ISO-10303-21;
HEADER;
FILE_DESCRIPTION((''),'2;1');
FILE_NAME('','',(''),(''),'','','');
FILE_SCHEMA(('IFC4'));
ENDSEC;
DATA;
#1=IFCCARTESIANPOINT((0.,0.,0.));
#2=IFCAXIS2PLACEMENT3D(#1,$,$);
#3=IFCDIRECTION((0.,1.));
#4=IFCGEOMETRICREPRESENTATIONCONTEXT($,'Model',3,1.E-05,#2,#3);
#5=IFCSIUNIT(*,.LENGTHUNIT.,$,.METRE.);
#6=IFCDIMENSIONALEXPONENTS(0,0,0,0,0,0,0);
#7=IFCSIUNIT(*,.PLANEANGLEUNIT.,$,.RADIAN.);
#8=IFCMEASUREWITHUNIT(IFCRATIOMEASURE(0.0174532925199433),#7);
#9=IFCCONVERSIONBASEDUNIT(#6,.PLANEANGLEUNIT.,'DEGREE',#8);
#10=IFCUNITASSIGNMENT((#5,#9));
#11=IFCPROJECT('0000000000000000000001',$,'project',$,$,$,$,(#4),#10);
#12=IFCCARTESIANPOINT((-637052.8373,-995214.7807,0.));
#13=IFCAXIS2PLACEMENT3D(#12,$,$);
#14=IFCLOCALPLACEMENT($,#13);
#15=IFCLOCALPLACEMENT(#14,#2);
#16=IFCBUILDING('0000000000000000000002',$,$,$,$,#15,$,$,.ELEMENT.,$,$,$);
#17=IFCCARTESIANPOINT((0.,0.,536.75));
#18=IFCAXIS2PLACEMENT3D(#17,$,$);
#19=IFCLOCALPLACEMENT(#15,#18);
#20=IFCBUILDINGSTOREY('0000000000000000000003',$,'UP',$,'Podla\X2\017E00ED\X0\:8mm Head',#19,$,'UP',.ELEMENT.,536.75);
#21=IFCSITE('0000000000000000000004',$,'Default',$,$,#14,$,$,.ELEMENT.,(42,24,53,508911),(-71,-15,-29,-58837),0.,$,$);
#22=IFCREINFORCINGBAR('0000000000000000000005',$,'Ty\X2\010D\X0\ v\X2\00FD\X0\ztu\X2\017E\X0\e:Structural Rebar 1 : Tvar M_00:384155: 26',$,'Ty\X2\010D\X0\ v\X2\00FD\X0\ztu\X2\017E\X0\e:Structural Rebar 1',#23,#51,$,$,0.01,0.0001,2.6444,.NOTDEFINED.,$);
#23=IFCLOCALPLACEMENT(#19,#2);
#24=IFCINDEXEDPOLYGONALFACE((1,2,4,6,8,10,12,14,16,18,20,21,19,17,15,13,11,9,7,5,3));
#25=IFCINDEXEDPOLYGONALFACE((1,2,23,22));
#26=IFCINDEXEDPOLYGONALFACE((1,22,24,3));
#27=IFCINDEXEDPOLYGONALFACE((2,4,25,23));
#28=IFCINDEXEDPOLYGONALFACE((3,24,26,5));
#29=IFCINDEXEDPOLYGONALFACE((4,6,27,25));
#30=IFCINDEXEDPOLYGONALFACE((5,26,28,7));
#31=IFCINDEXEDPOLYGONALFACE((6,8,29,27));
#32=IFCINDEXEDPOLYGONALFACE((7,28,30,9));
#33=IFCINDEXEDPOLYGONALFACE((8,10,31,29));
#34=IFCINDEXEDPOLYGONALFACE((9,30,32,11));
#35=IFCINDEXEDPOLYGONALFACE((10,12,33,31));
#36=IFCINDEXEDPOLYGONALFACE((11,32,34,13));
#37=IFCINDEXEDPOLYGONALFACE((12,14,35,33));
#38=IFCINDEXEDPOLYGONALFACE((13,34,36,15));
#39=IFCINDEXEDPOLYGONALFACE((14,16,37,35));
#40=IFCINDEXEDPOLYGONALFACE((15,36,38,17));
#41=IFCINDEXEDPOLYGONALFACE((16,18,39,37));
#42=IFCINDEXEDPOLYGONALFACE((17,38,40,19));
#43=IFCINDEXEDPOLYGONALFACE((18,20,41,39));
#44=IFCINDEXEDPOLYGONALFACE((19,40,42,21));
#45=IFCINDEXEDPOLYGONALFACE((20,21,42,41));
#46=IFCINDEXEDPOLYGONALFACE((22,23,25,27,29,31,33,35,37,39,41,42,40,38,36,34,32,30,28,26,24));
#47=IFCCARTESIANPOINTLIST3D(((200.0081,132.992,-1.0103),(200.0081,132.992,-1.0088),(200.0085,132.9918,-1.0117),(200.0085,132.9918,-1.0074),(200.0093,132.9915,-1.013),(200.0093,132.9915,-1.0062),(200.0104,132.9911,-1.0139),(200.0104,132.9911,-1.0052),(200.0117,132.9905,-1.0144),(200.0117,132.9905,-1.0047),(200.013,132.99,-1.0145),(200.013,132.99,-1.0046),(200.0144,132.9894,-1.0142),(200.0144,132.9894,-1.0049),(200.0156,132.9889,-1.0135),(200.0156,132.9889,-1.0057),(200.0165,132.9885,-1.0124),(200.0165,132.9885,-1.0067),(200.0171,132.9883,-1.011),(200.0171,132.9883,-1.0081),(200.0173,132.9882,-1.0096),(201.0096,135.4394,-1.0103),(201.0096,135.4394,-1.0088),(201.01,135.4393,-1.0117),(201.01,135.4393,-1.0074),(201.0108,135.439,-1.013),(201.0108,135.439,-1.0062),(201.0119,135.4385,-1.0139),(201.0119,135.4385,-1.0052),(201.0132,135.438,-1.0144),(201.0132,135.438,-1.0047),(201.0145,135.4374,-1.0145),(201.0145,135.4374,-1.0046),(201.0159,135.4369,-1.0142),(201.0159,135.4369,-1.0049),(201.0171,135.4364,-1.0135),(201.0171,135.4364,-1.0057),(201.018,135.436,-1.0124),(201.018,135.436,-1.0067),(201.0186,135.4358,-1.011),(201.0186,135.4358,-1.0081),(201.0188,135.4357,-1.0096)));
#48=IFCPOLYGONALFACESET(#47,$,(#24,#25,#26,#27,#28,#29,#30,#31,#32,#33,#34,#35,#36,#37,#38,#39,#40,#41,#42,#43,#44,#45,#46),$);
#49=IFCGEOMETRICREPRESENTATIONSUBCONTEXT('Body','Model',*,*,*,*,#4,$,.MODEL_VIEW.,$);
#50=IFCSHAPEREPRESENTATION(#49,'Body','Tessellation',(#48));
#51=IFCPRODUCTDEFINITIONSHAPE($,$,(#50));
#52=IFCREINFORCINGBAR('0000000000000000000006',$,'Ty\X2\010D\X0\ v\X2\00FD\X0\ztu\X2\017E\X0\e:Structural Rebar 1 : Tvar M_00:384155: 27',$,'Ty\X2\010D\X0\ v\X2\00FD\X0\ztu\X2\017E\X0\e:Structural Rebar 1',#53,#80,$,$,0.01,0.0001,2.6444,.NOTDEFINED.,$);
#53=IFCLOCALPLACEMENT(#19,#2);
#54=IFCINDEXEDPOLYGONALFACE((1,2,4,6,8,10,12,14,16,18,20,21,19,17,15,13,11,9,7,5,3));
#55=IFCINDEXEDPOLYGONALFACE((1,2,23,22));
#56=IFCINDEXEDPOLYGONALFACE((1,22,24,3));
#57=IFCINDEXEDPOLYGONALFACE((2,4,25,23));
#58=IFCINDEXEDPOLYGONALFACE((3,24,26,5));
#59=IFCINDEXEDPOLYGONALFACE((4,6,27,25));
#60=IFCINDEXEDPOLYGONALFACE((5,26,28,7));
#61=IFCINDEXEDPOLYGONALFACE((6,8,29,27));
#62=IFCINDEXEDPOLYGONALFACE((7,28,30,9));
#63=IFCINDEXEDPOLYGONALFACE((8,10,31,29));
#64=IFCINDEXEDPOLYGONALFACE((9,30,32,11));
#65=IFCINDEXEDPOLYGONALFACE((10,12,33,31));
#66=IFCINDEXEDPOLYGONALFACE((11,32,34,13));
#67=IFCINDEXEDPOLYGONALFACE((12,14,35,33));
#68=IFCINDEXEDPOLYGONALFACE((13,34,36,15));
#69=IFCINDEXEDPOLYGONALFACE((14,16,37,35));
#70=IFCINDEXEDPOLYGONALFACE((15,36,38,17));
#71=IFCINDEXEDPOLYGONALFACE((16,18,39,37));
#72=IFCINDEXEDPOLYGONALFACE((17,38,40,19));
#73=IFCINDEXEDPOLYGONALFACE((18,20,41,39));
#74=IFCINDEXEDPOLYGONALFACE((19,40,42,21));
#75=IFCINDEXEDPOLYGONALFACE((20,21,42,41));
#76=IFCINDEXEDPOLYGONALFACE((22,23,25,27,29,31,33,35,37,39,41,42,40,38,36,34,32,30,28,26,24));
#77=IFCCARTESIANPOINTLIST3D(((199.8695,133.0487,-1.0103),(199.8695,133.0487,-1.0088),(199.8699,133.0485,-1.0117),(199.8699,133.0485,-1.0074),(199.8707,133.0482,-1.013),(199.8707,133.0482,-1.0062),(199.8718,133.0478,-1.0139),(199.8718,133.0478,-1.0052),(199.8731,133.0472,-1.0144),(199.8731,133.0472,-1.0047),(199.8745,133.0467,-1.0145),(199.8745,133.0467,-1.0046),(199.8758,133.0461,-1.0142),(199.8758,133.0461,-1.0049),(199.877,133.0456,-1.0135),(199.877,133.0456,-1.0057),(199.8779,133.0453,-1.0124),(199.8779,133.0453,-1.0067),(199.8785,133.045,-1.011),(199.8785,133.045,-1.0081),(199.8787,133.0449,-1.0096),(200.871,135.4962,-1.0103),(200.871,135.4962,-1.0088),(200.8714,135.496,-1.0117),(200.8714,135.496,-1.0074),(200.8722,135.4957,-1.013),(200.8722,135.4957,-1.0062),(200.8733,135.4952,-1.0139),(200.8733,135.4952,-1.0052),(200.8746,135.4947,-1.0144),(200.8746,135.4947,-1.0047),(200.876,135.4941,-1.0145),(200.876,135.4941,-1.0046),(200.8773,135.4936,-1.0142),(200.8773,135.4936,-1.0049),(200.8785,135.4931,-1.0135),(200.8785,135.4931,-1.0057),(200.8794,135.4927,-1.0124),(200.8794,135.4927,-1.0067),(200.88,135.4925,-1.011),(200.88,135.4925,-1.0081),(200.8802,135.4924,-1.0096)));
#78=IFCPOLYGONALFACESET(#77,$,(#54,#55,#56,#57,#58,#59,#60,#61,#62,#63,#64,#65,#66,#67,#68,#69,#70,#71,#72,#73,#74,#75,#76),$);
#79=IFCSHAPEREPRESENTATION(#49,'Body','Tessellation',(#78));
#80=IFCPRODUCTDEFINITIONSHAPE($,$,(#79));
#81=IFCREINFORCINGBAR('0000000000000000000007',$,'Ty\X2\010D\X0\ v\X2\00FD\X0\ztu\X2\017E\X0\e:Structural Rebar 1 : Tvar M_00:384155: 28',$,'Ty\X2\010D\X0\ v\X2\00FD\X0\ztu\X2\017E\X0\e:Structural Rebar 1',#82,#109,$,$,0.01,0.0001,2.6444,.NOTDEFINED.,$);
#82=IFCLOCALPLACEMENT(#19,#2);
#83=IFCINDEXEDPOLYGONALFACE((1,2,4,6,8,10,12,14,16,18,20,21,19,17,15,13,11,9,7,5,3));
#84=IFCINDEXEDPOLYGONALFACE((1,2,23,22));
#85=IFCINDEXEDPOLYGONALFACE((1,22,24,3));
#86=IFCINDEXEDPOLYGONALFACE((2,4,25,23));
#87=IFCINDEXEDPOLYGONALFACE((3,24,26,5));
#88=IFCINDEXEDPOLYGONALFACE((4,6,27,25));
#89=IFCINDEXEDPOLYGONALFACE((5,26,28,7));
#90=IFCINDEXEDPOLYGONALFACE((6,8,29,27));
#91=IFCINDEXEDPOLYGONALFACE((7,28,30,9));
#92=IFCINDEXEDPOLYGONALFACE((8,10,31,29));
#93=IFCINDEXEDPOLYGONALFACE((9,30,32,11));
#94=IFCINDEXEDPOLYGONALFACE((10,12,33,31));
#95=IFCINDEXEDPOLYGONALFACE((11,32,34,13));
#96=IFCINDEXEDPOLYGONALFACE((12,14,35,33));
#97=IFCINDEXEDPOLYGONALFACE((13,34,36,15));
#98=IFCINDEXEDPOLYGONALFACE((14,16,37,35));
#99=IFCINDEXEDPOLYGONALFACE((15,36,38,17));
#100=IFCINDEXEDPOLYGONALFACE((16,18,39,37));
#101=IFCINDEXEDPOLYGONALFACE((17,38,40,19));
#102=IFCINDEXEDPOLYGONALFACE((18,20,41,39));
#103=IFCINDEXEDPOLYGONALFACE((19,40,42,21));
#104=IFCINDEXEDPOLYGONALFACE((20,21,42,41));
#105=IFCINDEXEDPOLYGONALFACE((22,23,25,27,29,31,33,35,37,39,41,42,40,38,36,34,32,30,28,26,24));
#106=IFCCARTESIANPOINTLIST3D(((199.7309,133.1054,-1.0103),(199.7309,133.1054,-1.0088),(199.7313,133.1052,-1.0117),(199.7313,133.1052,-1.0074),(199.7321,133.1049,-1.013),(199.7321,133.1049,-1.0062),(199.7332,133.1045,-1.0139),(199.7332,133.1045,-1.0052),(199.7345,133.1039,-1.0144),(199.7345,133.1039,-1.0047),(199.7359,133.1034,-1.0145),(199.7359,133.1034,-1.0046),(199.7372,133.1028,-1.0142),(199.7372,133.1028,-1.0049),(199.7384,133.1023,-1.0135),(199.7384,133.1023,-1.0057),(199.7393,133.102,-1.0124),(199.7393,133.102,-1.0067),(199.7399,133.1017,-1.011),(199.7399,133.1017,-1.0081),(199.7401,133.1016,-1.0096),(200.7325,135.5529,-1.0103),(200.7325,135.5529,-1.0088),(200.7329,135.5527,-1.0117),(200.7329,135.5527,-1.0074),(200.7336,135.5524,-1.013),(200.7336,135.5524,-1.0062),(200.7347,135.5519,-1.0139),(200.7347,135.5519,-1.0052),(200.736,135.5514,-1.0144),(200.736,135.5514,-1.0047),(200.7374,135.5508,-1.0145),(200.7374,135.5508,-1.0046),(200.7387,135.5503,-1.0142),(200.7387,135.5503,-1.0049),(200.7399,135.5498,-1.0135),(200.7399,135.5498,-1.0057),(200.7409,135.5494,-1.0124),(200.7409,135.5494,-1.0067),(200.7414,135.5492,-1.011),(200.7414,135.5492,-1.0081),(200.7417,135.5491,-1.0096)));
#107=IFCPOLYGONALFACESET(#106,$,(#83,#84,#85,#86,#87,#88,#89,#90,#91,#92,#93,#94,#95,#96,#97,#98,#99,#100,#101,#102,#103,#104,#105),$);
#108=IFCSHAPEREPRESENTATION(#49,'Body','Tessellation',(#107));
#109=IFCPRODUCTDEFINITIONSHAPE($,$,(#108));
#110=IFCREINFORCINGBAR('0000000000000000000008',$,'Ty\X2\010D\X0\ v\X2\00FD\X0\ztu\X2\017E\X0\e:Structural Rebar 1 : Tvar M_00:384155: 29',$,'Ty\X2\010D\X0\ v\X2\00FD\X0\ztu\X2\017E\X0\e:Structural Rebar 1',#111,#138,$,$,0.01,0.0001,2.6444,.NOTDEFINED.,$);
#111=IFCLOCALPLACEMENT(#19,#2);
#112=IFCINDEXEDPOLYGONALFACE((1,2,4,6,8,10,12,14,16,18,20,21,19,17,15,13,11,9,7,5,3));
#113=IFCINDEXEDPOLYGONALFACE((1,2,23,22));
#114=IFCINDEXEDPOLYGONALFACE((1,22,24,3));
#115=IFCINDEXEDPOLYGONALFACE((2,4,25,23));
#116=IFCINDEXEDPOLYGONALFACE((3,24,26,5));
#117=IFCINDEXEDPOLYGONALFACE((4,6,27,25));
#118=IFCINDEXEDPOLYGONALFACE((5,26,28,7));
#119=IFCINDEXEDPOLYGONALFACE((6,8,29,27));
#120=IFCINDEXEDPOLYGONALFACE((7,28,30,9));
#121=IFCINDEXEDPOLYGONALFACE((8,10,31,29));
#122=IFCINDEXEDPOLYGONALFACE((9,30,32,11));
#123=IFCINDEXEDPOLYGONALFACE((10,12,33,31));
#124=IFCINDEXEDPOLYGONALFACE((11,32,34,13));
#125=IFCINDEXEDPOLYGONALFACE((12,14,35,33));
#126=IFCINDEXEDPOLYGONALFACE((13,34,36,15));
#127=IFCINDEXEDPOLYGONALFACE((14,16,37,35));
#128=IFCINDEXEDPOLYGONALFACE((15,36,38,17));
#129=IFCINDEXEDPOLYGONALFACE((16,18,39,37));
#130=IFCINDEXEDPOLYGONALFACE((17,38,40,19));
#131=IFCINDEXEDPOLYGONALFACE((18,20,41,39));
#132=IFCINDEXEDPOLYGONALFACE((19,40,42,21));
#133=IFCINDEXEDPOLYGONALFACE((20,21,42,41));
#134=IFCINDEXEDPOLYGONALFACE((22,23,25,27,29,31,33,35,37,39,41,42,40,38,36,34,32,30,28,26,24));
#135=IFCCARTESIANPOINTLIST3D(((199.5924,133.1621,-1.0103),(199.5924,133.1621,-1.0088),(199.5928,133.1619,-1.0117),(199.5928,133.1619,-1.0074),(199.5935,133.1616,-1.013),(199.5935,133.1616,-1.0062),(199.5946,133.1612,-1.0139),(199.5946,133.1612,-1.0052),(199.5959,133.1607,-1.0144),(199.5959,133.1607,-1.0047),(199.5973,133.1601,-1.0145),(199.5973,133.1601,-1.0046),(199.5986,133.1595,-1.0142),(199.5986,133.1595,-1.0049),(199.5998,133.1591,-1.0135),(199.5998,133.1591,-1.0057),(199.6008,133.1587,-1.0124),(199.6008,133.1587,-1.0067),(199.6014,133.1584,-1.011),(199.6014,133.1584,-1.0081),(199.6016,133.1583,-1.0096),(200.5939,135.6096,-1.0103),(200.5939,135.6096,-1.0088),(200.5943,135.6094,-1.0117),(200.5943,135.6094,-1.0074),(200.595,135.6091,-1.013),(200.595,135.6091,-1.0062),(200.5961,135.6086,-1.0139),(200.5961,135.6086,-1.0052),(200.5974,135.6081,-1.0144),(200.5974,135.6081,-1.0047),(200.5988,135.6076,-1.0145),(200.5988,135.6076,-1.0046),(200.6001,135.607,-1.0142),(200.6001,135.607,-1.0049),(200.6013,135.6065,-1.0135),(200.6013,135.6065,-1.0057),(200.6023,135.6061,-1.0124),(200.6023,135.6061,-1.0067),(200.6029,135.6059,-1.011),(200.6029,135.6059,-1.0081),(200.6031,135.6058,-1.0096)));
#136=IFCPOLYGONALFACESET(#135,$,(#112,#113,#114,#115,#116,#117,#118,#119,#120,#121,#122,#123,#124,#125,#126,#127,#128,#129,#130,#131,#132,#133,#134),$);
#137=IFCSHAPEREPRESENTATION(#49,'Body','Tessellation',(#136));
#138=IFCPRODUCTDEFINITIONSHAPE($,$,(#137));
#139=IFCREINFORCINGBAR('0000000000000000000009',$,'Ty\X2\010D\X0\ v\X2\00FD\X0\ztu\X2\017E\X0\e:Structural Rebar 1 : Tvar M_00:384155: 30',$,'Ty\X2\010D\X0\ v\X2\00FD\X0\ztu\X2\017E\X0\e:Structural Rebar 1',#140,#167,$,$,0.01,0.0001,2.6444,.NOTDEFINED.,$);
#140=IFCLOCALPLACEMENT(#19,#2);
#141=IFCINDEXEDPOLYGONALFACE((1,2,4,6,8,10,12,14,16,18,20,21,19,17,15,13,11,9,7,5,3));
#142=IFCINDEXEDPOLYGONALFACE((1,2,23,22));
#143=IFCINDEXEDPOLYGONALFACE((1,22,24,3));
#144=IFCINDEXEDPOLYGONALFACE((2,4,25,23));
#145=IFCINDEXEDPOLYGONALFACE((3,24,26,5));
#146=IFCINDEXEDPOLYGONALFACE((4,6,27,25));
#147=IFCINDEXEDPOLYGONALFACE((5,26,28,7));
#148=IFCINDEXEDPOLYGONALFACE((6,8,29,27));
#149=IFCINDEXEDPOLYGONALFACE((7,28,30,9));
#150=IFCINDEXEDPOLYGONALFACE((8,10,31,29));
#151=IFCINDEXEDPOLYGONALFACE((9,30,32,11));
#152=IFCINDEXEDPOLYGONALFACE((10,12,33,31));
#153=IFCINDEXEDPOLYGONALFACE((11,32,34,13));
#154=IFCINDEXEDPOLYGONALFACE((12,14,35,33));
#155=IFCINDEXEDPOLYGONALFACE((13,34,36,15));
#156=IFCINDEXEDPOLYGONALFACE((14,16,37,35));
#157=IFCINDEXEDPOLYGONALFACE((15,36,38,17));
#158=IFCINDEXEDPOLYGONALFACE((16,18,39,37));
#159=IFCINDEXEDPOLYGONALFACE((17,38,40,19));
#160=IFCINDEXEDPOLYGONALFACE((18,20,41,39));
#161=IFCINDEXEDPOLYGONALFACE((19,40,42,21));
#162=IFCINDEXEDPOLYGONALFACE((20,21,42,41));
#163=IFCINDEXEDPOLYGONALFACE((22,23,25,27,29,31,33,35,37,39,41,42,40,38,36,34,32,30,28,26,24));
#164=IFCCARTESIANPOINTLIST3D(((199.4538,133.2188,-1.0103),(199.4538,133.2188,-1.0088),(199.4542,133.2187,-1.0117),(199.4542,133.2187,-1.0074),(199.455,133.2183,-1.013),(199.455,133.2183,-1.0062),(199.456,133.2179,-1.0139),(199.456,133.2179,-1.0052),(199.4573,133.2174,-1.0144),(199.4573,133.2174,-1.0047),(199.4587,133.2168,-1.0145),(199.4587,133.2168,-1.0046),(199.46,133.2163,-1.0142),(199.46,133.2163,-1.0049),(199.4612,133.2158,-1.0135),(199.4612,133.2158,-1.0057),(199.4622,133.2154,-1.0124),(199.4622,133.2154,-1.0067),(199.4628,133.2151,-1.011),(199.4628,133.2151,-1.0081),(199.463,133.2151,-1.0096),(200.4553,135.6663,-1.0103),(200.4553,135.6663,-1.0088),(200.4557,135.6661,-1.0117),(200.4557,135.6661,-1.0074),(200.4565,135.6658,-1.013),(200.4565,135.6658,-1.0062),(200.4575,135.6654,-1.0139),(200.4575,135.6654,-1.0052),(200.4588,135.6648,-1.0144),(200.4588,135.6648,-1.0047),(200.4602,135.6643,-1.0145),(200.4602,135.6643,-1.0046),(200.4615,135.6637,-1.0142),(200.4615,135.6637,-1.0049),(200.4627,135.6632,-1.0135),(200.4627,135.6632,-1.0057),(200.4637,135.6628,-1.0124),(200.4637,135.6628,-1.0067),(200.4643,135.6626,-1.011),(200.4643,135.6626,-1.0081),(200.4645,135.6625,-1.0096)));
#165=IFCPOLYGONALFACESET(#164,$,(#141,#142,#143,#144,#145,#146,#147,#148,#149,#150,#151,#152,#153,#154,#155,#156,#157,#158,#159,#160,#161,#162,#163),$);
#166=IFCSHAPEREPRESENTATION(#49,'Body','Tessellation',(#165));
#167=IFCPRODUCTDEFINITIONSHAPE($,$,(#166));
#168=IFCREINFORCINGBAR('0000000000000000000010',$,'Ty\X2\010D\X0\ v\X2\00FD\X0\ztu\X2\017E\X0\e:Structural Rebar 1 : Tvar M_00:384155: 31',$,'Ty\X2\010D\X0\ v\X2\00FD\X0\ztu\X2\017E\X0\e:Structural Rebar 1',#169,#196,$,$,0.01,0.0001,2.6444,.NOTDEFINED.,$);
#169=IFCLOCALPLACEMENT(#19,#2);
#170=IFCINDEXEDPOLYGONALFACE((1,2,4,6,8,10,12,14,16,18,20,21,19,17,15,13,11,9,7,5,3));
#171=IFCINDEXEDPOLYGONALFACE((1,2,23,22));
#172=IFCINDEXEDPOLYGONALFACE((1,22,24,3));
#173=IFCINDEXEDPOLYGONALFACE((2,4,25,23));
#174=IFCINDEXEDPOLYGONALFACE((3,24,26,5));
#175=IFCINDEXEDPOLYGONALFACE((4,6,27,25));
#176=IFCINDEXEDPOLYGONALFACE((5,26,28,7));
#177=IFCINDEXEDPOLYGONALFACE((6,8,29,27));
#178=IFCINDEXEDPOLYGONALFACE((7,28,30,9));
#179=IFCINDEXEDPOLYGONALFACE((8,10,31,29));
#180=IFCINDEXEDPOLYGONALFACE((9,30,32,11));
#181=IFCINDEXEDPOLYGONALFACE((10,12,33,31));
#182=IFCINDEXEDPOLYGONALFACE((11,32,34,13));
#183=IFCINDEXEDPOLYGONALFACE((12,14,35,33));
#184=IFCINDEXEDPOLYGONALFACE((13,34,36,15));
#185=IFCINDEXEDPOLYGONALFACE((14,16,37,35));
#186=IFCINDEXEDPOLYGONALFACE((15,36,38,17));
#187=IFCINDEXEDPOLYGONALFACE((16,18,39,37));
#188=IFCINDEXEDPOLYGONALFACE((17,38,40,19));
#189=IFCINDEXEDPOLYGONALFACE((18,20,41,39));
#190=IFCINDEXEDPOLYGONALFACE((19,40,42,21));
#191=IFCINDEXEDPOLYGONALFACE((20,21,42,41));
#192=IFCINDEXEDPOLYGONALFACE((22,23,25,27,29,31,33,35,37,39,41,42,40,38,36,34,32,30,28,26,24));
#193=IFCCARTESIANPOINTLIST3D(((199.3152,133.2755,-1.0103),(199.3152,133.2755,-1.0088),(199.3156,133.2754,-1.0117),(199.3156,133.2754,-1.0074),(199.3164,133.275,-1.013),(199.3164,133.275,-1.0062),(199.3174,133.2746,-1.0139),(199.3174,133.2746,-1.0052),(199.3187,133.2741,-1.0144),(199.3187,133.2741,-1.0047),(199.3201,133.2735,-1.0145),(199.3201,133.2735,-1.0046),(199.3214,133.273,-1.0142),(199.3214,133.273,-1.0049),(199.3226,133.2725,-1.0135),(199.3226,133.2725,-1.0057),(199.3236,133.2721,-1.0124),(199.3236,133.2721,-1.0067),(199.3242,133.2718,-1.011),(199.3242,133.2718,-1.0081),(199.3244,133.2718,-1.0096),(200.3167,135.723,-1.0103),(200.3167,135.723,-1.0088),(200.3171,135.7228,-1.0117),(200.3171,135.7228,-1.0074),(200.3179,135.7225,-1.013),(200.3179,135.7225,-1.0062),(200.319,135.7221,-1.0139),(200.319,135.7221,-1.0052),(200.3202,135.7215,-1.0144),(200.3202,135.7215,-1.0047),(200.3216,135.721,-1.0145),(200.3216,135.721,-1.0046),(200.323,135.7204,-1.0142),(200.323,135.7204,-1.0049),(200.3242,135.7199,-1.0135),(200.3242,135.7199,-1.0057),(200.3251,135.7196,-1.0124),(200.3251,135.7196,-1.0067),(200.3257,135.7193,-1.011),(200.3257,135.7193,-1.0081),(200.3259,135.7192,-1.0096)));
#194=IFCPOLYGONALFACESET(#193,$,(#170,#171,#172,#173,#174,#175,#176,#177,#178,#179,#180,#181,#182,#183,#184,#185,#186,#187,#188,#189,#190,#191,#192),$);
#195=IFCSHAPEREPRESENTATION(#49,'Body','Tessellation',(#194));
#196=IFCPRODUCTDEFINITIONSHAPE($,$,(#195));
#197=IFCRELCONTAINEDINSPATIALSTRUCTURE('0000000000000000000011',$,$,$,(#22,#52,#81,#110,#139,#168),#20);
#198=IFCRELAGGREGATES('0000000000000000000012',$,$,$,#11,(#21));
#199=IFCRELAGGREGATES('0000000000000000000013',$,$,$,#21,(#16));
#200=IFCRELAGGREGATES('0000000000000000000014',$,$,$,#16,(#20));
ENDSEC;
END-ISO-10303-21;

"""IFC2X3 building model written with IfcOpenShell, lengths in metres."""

from ifc_helpers import new_model, entity, si_unit, converted_unit, direction, frame, origin, place, context, subcontext, project, spatial, element, save


model = new_model("IFC2X3")

# Units and contexts
model_context = context("Model", 3, precision=1e-05, world=origin(), true_north=direction((0.0, 1.0)))
body_context = subcontext(model_context, "Body", "Model", "MODEL_VIEW")
ifc_project = project(units=[si_unit("LENGTHUNIT", "METRE"), converted_unit("PLANEANGLEUNIT", "DEGREE", entity("IfcRatioMeasure", 0.0174532925199433), si_unit("PLANEANGLEUNIT", "RADIAN"), dimensions=[0, 0, 0, 0, 0, 0, 0])], contexts=[model_context])

# Site, building, storey
site_placement = place(None, frame((-637052.8373, -995214.7807, 0.0)))
site = spatial("IfcSite", under=ifc_project, at=site_placement, Name="Default", CompositionType="ELEMENT", RefLatitude=(42, 24, 53, 508911), RefLongitude=(-71, -15, -29, -58837), RefElevation=0.0)
building_placement = place(site_placement, origin())
building = spatial("IfcBuilding", under=site, at=building_placement, CompositionType="ELEMENT")
storey_placement = place(building_placement, frame((0.0, 0.0, 536.75)))
storey = spatial("IfcBuildingStorey", under=building, at=storey_placement, Name="UP", ObjectType="Podlaží:8mm Head", LongName="UP", CompositionType="ELEMENT", Elevation=536.75)

# Reinforcing bars
reinforcing_bar_1_placement = place(storey_placement, origin())
element("IfcReinforcingBar", 1, at=reinforcing_bar_1_placement, inside=storey, Name="Tyč výztuže:Structural Rebar 1 : Tvar M_00:384155: 26", ObjectType="Tyč výztuže:Structural Rebar 1", BarLength=2.6444, BarRole="NOTDEFINED", CrossSectionArea=0.0001, NominalDiameter=0.01, context=body_context, shape_type="AdvancedSweptSolid", body=[
    entity("IfcSweptDiskSolid", entity("IfcCompositeCurve", [entity("IfcCompositeCurveSegment", "CONTINUOUS", True, entity("IfcPolyline", [entity("IfcCartesianPoint", [-201.0142, -135.4376, 1.0096]), entity("IfcCartesianPoint", [-200.0127, -132.9901, 1.0096])]))], False), 0.005, None, 0.0, 1.0),
])
reinforcing_bar_2_placement = place(storey_placement, origin())
element("IfcReinforcingBar", 2, at=reinforcing_bar_2_placement, inside=storey, Name="Tyč výztuže:Structural Rebar 1 : Tvar M_00:384155: 27", ObjectType="Tyč výztuže:Structural Rebar 1", BarLength=2.6444, BarRole="NOTDEFINED", CrossSectionArea=0.0001, NominalDiameter=0.01, context=body_context, shape_type="AdvancedSweptSolid", body=[
    entity("IfcSweptDiskSolid", entity("IfcCompositeCurve", [entity("IfcCompositeCurveSegment", "CONTINUOUS", True, entity("IfcPolyline", [entity("IfcCartesianPoint", [-200.8756, -135.4943, 1.0096]), entity("IfcCartesianPoint", [-199.8741, -133.0468, 1.0096])]))], False), 0.005, None, 0.0, 1.0),
])
reinforcing_bar_3_placement = place(storey_placement, origin())
element("IfcReinforcingBar", 3, at=reinforcing_bar_3_placement, inside=storey, Name="Tyč výztuže:Structural Rebar 1 : Tvar M_00:384155: 28", ObjectType="Tyč výztuže:Structural Rebar 1", BarLength=2.6444, BarRole="NOTDEFINED", CrossSectionArea=0.0001, NominalDiameter=0.01, context=body_context, shape_type="AdvancedSweptSolid", body=[
    entity("IfcSweptDiskSolid", entity("IfcCompositeCurve", [entity("IfcCompositeCurveSegment", "CONTINUOUS", True, entity("IfcPolyline", [entity("IfcCartesianPoint", [-200.737, -135.551, 1.0096]), entity("IfcCartesianPoint", [-199.7355, -133.1035, 1.0096])]))], False), 0.005, None, 0.0, 1.0),
])
reinforcing_bar_4_placement = place(storey_placement, origin())
element("IfcReinforcingBar", 4, at=reinforcing_bar_4_placement, inside=storey, Name="Tyč výztuže:Structural Rebar 1 : Tvar M_00:384155: 29", ObjectType="Tyč výztuže:Structural Rebar 1", BarLength=2.6444, BarRole="NOTDEFINED", CrossSectionArea=0.0001, NominalDiameter=0.01, context=body_context, shape_type="AdvancedSweptSolid", body=[
    entity("IfcSweptDiskSolid", entity("IfcCompositeCurve", [entity("IfcCompositeCurveSegment", "CONTINUOUS", True, entity("IfcPolyline", [entity("IfcCartesianPoint", [-200.5984, -135.6077, 1.0096]), entity("IfcCartesianPoint", [-199.5969, -133.1602, 1.0096])]))], False), 0.005, None, 0.0, 1.0),
])
reinforcing_bar_5_placement = place(storey_placement, origin())
element("IfcReinforcingBar", 5, at=reinforcing_bar_5_placement, inside=storey, Name="Tyč výztuže:Structural Rebar 1 : Tvar M_00:384155: 30", ObjectType="Tyč výztuže:Structural Rebar 1", BarLength=2.6444, BarRole="NOTDEFINED", CrossSectionArea=0.0001, NominalDiameter=0.01, context=body_context, shape_type="AdvancedSweptSolid", body=[
    entity("IfcSweptDiskSolid", entity("IfcCompositeCurve", [entity("IfcCompositeCurveSegment", "CONTINUOUS", True, entity("IfcPolyline", [entity("IfcCartesianPoint", [-200.4599, -135.6644, 1.0096]), entity("IfcCartesianPoint", [-199.4583, -133.2169, 1.0096])]))], False), 0.005, None, 0.0, 1.0),
])
reinforcing_bar_6_placement = place(storey_placement, origin())
element("IfcReinforcingBar", 6, at=reinforcing_bar_6_placement, inside=storey, Name="Tyč výztuže:Structural Rebar 1 : Tvar M_00:384155: 31", ObjectType="Tyč výztuže:Structural Rebar 1", BarLength=2.6444, BarRole="NOTDEFINED", CrossSectionArea=0.0001, NominalDiameter=0.01, context=body_context, shape_type="AdvancedSweptSolid", body=[
    entity("IfcSweptDiskSolid", entity("IfcCompositeCurve", [entity("IfcCompositeCurveSegment", "CONTINUOUS", True, entity("IfcPolyline", [entity("IfcCartesianPoint", [-200.3213, -135.7211, 1.0096]), entity("IfcCartesianPoint", [-199.3198, -133.2737, 1.0096])]))], False), 0.005, None, 0.0, 1.0),
])

save(model, "model.ifc")
